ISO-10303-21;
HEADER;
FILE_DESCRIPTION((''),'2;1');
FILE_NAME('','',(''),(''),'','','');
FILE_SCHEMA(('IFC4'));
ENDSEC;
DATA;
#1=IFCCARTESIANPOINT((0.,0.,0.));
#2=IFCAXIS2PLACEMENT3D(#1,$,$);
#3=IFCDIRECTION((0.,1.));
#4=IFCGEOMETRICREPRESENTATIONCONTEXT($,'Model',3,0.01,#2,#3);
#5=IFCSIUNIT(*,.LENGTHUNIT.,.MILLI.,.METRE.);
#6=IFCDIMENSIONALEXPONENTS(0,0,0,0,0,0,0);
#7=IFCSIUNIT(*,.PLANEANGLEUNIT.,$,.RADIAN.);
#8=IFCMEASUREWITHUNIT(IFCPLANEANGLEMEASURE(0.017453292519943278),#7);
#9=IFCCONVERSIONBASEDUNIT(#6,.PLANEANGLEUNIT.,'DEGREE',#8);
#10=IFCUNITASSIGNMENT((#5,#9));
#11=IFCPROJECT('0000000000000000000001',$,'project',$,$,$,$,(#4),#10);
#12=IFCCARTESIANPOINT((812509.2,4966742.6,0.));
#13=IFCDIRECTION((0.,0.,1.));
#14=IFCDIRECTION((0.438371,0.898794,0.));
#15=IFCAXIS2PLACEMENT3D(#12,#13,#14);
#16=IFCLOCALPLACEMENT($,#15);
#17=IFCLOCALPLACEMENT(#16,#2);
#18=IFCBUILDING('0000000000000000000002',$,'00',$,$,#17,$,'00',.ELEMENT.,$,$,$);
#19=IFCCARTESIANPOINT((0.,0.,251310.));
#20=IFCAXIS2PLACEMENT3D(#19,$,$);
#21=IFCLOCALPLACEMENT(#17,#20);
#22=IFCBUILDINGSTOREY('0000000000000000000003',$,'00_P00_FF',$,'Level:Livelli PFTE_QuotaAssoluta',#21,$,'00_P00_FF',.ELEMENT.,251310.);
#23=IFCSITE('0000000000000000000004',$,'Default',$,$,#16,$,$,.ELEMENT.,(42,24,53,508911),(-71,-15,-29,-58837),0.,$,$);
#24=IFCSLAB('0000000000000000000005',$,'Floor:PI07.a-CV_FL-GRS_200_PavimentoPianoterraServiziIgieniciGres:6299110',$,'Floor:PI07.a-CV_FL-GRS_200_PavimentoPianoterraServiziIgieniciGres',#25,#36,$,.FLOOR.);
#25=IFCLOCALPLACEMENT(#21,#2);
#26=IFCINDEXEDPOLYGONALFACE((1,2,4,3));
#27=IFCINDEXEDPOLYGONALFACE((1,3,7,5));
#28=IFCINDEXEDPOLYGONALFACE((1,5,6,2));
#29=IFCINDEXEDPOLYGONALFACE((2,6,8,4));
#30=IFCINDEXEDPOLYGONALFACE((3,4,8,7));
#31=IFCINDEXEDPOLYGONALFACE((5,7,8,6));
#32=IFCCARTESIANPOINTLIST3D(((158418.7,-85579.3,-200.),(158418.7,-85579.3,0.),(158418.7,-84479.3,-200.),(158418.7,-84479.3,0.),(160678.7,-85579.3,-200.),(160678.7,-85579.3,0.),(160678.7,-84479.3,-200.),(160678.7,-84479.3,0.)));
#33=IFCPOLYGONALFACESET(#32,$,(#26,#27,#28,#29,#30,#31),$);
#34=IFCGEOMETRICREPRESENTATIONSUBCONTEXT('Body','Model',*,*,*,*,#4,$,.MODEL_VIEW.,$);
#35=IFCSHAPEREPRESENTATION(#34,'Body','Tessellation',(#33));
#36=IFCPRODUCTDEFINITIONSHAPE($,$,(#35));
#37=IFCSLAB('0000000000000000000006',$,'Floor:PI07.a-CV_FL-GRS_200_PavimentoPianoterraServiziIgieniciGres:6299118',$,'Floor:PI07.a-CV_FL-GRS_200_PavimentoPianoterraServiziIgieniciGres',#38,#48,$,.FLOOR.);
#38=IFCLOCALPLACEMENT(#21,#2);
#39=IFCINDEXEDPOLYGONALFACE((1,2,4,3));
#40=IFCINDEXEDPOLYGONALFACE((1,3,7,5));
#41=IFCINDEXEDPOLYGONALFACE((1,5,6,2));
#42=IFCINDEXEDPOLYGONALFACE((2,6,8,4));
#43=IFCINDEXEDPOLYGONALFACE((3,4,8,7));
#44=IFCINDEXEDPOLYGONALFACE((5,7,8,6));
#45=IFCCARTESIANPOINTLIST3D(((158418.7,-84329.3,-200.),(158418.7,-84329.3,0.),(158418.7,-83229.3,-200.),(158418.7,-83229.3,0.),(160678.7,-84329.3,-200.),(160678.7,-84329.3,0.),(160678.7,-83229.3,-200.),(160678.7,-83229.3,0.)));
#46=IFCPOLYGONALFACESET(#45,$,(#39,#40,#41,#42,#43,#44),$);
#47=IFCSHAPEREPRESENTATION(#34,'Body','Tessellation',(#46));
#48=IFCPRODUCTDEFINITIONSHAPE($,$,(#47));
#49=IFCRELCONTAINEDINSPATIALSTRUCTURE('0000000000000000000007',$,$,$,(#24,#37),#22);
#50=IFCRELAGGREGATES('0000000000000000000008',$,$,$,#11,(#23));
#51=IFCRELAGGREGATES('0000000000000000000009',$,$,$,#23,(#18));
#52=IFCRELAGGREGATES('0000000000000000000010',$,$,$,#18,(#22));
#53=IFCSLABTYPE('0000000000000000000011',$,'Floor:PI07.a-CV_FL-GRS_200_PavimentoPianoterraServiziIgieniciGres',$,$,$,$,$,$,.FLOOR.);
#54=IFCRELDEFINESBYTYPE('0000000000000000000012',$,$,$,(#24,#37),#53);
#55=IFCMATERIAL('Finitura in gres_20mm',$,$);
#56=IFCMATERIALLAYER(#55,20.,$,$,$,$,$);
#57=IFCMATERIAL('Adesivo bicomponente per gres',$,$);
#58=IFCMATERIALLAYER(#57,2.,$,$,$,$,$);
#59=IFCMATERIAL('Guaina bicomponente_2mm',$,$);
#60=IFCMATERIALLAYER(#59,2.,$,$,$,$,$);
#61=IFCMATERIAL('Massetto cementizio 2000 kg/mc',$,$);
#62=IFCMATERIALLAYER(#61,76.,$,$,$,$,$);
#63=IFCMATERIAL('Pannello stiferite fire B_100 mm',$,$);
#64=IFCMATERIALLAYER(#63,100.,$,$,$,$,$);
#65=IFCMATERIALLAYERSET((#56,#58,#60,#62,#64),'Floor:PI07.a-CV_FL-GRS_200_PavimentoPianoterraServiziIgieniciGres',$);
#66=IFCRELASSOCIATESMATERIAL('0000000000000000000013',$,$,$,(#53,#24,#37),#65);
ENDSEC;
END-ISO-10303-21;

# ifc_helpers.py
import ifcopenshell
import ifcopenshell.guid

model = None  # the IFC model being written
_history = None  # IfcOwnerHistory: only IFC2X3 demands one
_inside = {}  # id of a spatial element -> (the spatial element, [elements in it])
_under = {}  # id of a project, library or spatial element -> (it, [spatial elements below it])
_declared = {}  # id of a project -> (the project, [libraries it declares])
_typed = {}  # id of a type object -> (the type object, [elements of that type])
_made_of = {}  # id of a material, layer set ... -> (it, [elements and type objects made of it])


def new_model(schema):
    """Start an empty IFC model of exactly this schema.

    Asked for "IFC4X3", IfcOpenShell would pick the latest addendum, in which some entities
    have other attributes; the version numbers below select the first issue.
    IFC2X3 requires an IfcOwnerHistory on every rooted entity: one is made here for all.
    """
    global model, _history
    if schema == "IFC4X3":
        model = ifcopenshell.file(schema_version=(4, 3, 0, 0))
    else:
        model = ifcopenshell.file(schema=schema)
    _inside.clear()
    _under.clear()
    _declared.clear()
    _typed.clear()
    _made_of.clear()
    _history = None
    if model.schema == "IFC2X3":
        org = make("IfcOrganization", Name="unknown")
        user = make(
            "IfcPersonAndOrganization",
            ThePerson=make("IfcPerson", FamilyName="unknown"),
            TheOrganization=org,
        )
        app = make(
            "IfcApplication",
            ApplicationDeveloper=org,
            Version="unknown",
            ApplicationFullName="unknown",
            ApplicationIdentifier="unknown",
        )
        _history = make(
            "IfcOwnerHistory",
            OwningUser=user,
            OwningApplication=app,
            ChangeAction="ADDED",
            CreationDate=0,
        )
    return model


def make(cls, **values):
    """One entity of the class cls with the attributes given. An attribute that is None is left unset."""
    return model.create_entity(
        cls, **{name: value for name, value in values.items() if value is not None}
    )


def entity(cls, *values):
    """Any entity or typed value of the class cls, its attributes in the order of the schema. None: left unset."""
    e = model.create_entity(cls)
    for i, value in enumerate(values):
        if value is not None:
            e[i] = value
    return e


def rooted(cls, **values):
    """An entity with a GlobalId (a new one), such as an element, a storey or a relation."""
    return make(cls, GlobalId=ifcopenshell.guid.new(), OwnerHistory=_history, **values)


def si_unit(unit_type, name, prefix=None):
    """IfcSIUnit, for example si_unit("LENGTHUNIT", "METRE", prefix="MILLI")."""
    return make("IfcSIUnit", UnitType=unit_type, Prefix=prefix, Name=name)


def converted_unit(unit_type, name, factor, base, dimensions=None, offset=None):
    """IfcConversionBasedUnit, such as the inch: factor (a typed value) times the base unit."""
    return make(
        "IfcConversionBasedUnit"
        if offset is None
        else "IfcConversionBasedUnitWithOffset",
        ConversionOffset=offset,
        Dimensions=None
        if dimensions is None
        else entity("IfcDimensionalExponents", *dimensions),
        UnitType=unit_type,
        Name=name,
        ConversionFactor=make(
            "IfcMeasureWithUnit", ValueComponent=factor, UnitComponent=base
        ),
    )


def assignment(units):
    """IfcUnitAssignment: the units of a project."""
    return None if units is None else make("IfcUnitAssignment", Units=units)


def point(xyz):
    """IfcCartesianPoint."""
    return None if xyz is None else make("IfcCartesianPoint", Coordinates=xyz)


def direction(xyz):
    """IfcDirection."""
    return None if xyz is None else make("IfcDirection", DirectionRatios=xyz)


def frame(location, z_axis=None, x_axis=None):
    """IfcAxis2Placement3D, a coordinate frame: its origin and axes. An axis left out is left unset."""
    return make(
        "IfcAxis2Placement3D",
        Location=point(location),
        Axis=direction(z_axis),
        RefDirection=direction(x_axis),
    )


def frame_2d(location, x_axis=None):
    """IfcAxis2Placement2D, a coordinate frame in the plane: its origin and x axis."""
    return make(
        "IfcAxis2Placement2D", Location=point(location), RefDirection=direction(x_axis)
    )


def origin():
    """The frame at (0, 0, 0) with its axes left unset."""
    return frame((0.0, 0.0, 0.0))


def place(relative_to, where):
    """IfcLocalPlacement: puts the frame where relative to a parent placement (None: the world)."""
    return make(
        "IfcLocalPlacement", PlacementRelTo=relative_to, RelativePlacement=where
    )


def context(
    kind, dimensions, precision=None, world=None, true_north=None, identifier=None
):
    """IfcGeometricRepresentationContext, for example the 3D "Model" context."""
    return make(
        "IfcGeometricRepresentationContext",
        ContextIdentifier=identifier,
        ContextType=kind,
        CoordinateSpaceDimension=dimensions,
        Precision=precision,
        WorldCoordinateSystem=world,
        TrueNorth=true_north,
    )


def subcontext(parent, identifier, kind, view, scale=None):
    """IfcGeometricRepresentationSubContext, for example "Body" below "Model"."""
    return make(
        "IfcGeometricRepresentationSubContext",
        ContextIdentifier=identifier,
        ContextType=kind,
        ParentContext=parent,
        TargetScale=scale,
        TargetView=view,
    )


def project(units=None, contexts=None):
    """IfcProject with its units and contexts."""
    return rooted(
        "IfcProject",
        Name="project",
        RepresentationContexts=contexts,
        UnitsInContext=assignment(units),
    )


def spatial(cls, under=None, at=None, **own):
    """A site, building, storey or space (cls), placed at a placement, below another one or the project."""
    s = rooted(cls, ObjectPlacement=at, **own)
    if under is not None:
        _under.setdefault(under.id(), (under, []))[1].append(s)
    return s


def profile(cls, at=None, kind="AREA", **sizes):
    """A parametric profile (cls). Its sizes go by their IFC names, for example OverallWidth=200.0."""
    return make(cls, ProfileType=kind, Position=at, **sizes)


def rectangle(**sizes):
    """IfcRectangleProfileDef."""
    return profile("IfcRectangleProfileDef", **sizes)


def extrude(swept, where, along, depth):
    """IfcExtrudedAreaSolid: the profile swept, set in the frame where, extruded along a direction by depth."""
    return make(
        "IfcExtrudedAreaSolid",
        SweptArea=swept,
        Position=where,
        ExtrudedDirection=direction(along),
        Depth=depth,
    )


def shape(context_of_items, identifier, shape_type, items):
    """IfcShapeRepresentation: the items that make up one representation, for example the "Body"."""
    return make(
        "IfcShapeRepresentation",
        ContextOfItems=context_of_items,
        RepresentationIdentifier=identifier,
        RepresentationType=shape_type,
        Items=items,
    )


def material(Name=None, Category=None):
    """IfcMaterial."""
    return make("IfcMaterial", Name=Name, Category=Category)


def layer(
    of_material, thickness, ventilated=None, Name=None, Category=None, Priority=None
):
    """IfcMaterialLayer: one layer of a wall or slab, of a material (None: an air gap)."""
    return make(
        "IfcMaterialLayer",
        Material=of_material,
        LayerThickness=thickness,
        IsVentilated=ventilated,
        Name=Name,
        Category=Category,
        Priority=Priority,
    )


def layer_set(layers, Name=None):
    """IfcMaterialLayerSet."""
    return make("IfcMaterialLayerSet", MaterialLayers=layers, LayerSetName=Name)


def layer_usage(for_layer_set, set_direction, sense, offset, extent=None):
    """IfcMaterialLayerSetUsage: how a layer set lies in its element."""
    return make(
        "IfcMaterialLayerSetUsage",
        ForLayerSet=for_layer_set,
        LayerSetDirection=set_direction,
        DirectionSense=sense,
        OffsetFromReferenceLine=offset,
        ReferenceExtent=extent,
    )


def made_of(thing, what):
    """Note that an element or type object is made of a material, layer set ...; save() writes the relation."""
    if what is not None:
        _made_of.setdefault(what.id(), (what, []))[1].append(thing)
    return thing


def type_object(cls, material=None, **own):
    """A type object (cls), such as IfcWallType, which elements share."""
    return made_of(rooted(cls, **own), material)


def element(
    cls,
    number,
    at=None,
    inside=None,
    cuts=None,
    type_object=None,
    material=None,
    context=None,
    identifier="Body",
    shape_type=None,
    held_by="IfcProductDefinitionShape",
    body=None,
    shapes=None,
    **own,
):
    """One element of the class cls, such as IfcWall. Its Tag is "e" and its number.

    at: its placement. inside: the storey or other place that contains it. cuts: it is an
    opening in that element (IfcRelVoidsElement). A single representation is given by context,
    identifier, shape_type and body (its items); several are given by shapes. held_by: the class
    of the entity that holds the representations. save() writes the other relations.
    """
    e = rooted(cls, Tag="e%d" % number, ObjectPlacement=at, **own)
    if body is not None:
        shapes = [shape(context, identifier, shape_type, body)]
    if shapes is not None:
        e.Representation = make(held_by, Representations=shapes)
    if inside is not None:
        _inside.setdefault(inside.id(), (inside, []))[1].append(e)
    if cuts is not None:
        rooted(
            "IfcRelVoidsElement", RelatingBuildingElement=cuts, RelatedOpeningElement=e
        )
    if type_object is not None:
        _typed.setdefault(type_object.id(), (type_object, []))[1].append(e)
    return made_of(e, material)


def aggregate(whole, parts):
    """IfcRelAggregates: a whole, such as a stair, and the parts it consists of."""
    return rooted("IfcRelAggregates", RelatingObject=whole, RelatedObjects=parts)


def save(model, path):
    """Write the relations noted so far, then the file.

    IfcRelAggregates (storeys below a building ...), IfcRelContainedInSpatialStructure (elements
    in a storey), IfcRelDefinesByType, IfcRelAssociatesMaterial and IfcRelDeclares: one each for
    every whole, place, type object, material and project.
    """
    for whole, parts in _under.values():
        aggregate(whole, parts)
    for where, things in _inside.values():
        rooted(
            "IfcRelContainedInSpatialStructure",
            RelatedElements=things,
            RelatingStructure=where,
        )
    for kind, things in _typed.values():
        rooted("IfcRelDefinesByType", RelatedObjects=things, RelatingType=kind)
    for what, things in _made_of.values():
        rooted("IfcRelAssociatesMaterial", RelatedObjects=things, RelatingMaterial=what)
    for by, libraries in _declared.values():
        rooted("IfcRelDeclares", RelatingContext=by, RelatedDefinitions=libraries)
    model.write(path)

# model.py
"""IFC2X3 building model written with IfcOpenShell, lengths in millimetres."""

from ifc_helpers import new_model, entity, si_unit, converted_unit, direction, frame, frame_2d, origin, place, context, subcontext, project, spatial, rectangle, extrude, material, layer, layer_set, layer_usage, type_object, element, save


model = new_model("IFC2X3")

# Units and contexts
model_context = context("Model", 3, precision=0.01, world=origin(), true_north=direction((0.0, 1.0)))
body_context = subcontext(model_context, "Body", "Model", "MODEL_VIEW")
ifc_project = project(units=[si_unit("LENGTHUNIT", "METRE", prefix="MILLI"), converted_unit("PLANEANGLEUNIT", "DEGREE", entity("IfcPlaneAngleMeasure", 0.017453292519943278), si_unit("PLANEANGLEUNIT", "RADIAN"), dimensions=[0, 0, 0, 0, 0, 0, 0])], contexts=[model_context])

# Site, building, storey
site_placement = place(None, frame((812509.2, 4966742.6, 0.0), z_axis=(0.0, 0.0, 1.0), x_axis=(0.438371, 0.898794, 0.0)))
site = spatial("IfcSite", under=ifc_project, at=site_placement, Name="Default", CompositionType="ELEMENT", RefLatitude=(42, 24, 53, 508911), RefLongitude=(-71, -15, -29, -58837), RefElevation=0.0)
building_placement = place(site_placement, origin())
building = spatial("IfcBuilding", under=site, at=building_placement, Name="00", LongName="00", CompositionType="ELEMENT")
storey_placement = place(building_placement, frame((0.0, 0.0, 251310.0)))
storey = spatial("IfcBuildingStorey", under=building, at=storey_placement, Name="00_P00_FF", ObjectType="Level:Livelli PFTE_QuotaAssoluta", LongName="00_P00_FF", CompositionType="ELEMENT", Elevation=251310.0)

# Slabs
ifc_material_1 = material(Name="Massetto cementizio 2000 kg/mc")
ifc_material_2 = material(Name="Pannello stiferite fire B_100 mm")
ifc_material_3 = material(Name="Finitura in gres_20mm")
ifc_layer_1 = layer(ifc_material_3, 20.0)
ifc_material_4 = material(Name="Adesivo bicomponente per gres")
ifc_layer_2 = layer(ifc_material_4, 2.0)
ifc_material_5 = material(Name="Guaina bicomponente_2mm")
ifc_layer_3 = layer(ifc_material_5, 2.0)
ifc_layer_4 = layer(ifc_material_1, 76.0)
ifc_layer_5 = layer(ifc_material_2, 100.0)
ifc_layer_set_1 = layer_set([ifc_layer_1, ifc_layer_2, ifc_layer_3, ifc_layer_4, ifc_layer_5], Name="Floor:PI07.a-CV_FL-GRS_200_PavimentoPianoterraServiziIgieniciGres")
slab_type_1 = type_object("IfcSlabType", Name="Floor:PI07.a-CV_FL-GRS_200_PavimentoPianoterraServiziIgieniciGres", PredefinedType="FLOOR", material=ifc_layer_set_1)
ifc_layer_usage_1 = layer_usage(ifc_layer_set_1, "AXIS3", "POSITIVE", 0.0)
slab_1_placement = place(storey_placement, origin())
element("IfcSlab", 1, at=slab_1_placement, inside=storey, type_object=slab_type_1, material=ifc_layer_usage_1, Name="Floor:PI07.a-CV_FL-GRS_200_PavimentoPianoterraServiziIgieniciGres:6299110", ObjectType="Floor:PI07.a-CV_FL-GRS_200_PavimentoPianoterraServiziIgieniciGres", PredefinedType="FLOOR", context=body_context, shape_type="SweptSolid", body=[
    extrude(rectangle(XDim=1100.0, YDim=2260.0, at=frame_2d((0.0, 0.0), x_axis=(1.0, 0.0))), frame((159548.7, -85029.3, 0.0), z_axis=(0.0, 0.0, -1.0), x_axis=(0.0, 1.0, 0.0)), (0.0, 0.0, 1.0), 200.0),
])
ifc_layer_usage_2 = layer_usage(ifc_layer_set_1, "AXIS3", "POSITIVE", 0.0)
slab_2_placement = place(storey_placement, origin())
element("IfcSlab", 2, at=slab_2_placement, inside=storey, type_object=slab_type_1, material=ifc_layer_usage_2, Name="Floor:PI07.a-CV_FL-GRS_200_PavimentoPianoterraServiziIgieniciGres:6299118", ObjectType="Floor:PI07.a-CV_FL-GRS_200_PavimentoPianoterraServiziIgieniciGres", PredefinedType="FLOOR", context=body_context, shape_type="SweptSolid", body=[
    extrude(rectangle(XDim=1100.0, YDim=2260.0, at=frame_2d((0.0, 0.0), x_axis=(1.0, 0.0))), frame((159548.7, -83779.3, 0.0), z_axis=(0.0, 0.0, -1.0), x_axis=(0.0, 1.0, 0.0)), (0.0, 0.0, 1.0), 200.0),
])

save(model, "model.ifc")
